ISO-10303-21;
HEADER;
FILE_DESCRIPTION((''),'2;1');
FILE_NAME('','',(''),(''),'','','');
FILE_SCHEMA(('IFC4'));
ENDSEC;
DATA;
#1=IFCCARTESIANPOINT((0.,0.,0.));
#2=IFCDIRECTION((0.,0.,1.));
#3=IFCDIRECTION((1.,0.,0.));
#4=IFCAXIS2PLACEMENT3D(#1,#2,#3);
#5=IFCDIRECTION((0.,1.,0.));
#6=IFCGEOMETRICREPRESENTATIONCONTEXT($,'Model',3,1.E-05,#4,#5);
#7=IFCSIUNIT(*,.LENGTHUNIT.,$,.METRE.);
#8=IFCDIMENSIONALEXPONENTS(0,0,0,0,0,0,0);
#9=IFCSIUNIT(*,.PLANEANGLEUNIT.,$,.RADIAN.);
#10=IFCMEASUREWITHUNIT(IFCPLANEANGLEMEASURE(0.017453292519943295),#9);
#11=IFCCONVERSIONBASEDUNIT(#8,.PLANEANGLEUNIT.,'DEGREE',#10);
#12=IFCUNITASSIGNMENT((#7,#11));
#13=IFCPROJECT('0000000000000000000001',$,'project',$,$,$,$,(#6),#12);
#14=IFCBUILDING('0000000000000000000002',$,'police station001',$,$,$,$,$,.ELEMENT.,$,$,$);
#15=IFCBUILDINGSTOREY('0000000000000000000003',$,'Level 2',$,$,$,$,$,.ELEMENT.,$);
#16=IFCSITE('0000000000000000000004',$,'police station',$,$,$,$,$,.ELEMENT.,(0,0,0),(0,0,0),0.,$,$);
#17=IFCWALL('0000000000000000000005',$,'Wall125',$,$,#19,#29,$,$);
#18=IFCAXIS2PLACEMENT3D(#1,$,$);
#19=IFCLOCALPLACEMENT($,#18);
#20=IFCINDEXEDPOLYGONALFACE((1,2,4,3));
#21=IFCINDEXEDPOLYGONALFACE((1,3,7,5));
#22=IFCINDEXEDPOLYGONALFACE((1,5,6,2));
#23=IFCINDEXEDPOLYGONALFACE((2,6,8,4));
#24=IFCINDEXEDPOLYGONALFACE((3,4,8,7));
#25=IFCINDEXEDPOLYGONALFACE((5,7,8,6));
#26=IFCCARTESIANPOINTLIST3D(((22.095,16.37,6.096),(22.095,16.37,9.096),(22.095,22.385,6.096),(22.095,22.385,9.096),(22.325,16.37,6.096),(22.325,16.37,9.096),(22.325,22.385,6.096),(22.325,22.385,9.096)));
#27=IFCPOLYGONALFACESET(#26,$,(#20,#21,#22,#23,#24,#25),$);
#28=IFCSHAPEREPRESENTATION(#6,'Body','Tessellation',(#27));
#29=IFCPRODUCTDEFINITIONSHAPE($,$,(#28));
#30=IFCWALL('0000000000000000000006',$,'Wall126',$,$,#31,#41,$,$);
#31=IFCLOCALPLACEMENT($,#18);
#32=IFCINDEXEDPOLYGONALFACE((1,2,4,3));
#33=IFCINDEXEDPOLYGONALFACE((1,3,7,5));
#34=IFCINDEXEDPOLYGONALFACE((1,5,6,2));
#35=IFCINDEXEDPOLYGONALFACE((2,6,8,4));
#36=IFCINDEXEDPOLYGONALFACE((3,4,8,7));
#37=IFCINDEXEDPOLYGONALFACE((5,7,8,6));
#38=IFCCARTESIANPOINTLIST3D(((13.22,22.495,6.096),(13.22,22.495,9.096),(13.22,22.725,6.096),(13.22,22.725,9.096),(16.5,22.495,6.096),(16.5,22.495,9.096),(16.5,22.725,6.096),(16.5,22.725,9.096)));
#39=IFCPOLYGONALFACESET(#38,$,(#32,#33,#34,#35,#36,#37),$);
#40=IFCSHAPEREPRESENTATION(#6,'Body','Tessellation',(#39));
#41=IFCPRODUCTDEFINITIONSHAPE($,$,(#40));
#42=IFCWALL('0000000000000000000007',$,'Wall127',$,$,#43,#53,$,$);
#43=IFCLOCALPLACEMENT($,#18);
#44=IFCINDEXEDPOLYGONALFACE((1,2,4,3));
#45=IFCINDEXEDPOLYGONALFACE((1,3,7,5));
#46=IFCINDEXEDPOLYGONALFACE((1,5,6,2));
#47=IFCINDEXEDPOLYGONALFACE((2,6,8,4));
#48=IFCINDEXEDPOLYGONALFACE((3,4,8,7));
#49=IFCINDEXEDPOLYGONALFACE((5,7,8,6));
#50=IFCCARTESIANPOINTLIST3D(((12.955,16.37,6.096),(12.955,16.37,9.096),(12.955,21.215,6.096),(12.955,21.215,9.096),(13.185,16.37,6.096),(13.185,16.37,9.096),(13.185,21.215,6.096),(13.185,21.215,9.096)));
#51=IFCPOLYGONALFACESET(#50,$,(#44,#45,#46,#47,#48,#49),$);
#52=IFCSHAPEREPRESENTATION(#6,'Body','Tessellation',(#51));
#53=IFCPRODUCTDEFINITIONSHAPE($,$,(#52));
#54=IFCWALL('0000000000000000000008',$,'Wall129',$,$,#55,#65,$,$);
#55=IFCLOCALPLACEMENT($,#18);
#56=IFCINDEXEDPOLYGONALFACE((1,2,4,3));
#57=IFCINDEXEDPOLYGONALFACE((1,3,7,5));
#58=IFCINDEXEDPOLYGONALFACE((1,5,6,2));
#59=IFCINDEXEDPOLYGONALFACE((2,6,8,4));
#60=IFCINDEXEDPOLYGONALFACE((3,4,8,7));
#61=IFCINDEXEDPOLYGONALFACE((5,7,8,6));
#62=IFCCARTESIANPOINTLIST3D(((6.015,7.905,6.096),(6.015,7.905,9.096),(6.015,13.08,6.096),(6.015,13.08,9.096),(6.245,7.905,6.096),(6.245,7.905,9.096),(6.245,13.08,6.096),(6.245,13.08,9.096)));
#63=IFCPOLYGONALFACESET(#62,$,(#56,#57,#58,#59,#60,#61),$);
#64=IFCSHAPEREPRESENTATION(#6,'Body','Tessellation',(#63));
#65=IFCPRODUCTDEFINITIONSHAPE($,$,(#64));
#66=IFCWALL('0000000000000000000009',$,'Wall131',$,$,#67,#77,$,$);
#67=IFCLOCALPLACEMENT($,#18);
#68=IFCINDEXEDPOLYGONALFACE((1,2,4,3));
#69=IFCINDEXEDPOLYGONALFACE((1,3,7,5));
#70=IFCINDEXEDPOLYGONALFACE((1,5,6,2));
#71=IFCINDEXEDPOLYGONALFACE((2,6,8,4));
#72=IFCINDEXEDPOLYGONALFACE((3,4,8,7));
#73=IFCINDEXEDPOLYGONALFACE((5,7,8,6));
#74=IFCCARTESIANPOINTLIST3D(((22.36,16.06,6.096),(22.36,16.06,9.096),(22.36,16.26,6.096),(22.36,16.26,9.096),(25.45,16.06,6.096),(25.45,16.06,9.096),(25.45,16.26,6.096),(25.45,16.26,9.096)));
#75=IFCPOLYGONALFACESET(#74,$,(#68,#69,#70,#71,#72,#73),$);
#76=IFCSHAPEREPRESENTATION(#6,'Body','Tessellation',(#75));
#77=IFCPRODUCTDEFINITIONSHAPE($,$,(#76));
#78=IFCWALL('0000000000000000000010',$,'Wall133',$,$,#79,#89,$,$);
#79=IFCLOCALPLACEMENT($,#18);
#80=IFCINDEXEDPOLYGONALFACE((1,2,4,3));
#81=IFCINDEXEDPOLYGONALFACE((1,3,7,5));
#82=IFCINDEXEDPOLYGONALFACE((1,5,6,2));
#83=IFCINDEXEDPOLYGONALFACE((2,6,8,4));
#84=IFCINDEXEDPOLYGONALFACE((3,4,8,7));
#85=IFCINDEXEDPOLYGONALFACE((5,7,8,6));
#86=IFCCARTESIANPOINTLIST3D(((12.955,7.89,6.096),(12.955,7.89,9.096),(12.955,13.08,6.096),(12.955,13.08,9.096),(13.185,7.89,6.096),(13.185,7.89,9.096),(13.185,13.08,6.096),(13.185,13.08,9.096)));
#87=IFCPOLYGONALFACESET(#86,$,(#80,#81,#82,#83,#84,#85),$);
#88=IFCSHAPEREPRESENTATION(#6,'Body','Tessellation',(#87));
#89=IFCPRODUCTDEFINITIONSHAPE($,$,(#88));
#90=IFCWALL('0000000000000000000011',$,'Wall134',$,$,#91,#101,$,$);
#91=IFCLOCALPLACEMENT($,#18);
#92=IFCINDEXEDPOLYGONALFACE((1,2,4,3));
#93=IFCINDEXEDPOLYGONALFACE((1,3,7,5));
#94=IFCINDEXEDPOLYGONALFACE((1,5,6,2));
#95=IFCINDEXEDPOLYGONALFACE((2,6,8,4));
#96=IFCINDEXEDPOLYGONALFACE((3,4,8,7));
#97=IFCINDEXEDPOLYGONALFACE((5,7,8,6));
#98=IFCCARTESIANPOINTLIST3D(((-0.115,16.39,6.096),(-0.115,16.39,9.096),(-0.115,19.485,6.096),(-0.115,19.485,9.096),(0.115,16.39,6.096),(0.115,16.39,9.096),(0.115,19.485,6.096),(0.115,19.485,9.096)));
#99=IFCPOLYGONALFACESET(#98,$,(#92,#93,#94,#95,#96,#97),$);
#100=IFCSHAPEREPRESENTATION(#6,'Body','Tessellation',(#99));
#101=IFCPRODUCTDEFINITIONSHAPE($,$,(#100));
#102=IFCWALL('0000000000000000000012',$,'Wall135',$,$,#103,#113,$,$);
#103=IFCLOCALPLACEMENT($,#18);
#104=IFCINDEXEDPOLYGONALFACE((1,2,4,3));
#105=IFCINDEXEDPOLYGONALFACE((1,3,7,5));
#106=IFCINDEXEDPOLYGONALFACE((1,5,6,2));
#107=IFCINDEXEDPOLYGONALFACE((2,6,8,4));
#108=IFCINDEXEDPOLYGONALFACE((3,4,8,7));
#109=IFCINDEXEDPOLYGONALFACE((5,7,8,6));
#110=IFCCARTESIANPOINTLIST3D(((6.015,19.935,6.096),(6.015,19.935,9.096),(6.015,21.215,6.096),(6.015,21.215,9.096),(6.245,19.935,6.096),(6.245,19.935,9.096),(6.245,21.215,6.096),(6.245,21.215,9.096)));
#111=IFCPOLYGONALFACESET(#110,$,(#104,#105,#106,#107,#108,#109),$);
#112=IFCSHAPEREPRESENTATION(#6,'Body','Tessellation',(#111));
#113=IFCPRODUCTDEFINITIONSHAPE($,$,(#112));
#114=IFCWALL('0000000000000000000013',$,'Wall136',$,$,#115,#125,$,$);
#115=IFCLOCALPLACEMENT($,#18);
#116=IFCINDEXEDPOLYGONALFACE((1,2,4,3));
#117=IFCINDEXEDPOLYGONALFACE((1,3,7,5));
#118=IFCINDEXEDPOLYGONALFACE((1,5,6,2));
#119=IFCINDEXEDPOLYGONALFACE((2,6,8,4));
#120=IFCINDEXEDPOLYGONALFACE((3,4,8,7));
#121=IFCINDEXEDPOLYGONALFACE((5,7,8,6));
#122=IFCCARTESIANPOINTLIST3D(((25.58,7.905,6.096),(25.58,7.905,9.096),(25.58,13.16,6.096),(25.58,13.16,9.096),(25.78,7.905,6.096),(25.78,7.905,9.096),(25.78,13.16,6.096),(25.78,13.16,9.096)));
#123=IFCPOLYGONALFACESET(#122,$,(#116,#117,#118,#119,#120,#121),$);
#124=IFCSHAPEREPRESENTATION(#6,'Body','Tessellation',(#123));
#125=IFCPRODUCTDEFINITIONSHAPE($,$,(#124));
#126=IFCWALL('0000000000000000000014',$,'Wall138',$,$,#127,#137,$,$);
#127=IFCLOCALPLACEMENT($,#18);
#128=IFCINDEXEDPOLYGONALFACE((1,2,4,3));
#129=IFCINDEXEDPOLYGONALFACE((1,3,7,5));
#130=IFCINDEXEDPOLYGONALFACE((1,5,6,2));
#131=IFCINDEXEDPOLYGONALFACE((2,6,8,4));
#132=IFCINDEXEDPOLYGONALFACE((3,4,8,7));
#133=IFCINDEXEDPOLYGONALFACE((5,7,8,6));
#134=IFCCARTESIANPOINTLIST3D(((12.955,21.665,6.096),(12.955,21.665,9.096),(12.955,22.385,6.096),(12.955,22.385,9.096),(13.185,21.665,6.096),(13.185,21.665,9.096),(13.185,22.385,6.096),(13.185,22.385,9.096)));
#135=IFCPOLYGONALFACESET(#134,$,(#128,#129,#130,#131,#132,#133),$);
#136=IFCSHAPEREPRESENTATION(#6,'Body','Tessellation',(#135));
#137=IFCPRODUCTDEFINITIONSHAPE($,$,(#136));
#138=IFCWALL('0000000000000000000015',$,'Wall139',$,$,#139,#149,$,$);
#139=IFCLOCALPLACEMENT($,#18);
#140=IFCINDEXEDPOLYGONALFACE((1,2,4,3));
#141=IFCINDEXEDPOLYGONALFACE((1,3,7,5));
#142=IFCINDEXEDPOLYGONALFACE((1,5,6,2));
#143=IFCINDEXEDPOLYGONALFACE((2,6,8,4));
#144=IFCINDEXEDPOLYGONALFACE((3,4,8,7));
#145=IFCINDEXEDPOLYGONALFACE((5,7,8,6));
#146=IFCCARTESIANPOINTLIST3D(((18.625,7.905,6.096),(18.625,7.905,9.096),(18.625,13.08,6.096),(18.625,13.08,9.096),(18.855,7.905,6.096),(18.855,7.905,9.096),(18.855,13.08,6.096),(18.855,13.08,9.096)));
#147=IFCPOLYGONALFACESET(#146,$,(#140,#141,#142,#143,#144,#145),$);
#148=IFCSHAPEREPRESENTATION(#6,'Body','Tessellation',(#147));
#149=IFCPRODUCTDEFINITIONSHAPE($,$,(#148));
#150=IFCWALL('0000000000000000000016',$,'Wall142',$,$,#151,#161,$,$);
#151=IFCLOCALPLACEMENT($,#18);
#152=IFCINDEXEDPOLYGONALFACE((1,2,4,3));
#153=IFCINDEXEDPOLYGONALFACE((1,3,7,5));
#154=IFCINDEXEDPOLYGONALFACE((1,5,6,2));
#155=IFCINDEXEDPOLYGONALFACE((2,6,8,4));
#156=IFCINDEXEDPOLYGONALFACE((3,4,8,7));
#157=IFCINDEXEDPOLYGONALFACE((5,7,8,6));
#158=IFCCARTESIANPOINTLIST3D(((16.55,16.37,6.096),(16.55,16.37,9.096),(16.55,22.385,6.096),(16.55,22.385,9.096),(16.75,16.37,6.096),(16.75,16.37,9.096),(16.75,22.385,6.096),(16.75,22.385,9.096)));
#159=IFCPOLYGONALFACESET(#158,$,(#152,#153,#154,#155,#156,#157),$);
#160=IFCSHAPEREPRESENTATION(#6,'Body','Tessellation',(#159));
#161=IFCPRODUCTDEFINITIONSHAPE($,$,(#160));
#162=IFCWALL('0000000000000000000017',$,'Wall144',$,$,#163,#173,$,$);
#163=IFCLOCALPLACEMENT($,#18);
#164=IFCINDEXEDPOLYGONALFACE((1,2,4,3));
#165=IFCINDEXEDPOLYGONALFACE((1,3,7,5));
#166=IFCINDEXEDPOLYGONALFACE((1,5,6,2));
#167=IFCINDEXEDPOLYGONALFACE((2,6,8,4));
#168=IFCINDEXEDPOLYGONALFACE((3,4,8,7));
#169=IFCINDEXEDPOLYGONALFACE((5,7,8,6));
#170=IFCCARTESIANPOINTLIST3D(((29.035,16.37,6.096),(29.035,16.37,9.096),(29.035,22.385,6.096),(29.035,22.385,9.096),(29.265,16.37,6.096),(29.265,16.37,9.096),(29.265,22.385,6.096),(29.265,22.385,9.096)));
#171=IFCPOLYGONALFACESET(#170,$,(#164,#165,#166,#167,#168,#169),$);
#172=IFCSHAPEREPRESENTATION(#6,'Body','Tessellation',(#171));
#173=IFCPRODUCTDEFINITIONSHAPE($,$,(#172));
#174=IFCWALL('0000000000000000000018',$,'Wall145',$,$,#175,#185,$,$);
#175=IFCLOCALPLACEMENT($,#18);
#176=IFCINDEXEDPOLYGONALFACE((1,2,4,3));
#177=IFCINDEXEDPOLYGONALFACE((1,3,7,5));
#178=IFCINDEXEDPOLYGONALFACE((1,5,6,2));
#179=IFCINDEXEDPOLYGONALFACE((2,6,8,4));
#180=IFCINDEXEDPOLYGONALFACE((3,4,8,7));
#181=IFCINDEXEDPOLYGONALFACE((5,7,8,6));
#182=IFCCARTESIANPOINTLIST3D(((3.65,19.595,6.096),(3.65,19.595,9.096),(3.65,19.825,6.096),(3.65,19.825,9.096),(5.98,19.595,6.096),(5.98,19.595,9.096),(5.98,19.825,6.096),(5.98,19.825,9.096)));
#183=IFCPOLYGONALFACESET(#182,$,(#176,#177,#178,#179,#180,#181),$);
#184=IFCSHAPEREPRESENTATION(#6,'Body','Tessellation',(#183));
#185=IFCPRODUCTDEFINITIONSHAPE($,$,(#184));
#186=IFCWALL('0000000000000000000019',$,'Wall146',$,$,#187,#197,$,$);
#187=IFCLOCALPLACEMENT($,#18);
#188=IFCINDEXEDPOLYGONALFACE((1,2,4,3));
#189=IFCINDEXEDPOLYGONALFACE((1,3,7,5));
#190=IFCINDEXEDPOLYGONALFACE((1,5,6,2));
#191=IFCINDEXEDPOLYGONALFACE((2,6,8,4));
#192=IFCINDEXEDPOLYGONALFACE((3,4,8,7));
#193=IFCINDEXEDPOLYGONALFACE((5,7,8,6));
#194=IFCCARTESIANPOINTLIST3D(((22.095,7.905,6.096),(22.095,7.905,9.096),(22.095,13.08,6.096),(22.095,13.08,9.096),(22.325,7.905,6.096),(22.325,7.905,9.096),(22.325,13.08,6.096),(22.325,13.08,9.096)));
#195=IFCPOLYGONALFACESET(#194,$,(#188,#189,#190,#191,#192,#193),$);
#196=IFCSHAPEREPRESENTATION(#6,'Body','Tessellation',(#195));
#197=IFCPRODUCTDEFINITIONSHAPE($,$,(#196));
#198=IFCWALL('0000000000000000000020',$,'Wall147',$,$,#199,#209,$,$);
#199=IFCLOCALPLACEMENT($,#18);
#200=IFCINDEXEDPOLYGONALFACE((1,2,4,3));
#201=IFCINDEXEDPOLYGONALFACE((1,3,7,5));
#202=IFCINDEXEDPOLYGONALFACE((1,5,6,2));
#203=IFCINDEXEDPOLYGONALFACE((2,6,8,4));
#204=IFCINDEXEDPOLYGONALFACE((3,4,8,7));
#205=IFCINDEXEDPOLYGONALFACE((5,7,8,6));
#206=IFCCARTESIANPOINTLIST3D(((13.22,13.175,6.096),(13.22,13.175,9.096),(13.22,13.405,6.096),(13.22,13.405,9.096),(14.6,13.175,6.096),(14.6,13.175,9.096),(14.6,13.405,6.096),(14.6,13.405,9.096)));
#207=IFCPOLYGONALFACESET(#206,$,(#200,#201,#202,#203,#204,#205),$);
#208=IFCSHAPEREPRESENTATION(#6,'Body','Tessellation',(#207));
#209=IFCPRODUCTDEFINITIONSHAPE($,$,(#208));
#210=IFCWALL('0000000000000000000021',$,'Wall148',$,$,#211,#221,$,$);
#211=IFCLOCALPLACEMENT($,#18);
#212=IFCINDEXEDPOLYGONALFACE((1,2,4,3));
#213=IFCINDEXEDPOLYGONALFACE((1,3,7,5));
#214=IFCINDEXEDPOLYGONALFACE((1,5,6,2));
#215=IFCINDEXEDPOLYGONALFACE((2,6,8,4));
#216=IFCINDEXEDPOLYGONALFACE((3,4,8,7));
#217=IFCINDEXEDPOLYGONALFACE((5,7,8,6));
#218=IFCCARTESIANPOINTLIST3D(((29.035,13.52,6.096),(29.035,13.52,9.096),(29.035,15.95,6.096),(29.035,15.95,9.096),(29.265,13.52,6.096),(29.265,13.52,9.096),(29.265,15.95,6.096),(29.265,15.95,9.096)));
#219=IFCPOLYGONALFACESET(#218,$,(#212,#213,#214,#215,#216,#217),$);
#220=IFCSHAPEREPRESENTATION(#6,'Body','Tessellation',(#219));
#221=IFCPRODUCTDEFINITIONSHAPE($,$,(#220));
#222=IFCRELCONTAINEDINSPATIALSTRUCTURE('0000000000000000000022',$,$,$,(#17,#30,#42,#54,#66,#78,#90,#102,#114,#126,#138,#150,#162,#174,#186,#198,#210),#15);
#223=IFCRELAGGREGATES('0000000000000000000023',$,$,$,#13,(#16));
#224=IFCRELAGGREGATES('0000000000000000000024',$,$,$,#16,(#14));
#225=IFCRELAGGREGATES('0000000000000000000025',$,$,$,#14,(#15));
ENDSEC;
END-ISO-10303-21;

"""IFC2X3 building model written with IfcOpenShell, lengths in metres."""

from ifc_helpers import new_model, entity, si_unit, converted_unit, direction, frame, frame_2d, origin_with_axes, place, context, project, spatial, rectangle, extrude, element, save


model = new_model("IFC2X3")

# Units and contexts
model_context = context("Model", 3, precision=1e-05, world=origin_with_axes(), true_north=direction((0.0, 1.0, 0.0)))
ifc_project = project(units=[si_unit("LENGTHUNIT", "METRE"), converted_unit("PLANEANGLEUNIT", "DEGREE", entity("IfcPlaneAngleMeasure", 0.017453292519943295), si_unit("PLANEANGLEUNIT", "RADIAN"), dimensions=[0, 0, 0, 0, 0, 0, 0])], contexts=[model_context])

# Site, building, storey
site = spatial("IfcSite", under=ifc_project, Name="police station", CompositionType="ELEMENT", RefLatitude=(0, 0, 0), RefLongitude=(0, 0, 0), RefElevation=0.0)
building = spatial("IfcBuilding", under=site, Name="police station001", CompositionType="ELEMENT")
storey = spatial("IfcBuildingStorey", under=building, Name="Level 2", CompositionType="ELEMENT")

# Shared definitions
placement = place(None, origin_with_axes())

# Walls
element("IfcWall", 1, at=placement, inside=storey, Name="Wall125", context=model_context, shape_type="SweptSolid", body=[
    extrude(rectangle(XDim=6.015, YDim=0.23, at=frame_2d((0.0, 0.0), x_axis=(0.0, -1.0, 0.0))), frame((22.21, 19.3775, 6.096), z_axis=(0.0, 0.0, 1.0), x_axis=(1.0, 0.0, 0.0)), (0.0, 0.0, 1.0), 3.0),
])
element("IfcWall", 2, at=placement, inside=storey, Name="Wall126", context=model_context, shape_type="SweptSolid", body=[
    extrude(rectangle(XDim=3.28, YDim=0.23, at=frame_2d((0.0, 0.0), x_axis=(-1.0, 0.0, 0.0))), frame((14.86, 22.61, 6.096), z_axis=(0.0, 0.0, 1.0), x_axis=(1.0, 0.0, 0.0)), (0.0, 0.0, 1.0), 3.0),
])
element("IfcWall", 3, at=placement, inside=storey, Name="Wall127", context=model_context, shape_type="SweptSolid", body=[
    extrude(rectangle(XDim=4.845, YDim=0.23, at=frame_2d((0.0, 0.0), x_axis=(0.0, -1.0, 0.0))), frame((13.07, 18.7925, 6.096), z_axis=(0.0, 0.0, 1.0), x_axis=(1.0, 0.0, 0.0)), (0.0, 0.0, 1.0), 3.0),
])
element("IfcWall", 4, at=placement, inside=storey, Name="Wall129", context=model_context, shape_type="SweptSolid", body=[
    extrude(rectangle(XDim=5.175, YDim=0.23, at=frame_2d((0.0, 0.0), x_axis=(0.0, -1.0, 0.0))), frame((6.13, 10.4925, 6.096), z_axis=(0.0, 0.0, 1.0), x_axis=(1.0, 0.0, 0.0)), (0.0, 0.0, 1.0), 3.0),
])
element("IfcWall", 5, at=placement, inside=storey, Name="Wall131", context=model_context, shape_type="SweptSolid", body=[
    extrude(rectangle(XDim=3.09, YDim=0.2, at=frame_2d((0.0, 0.0), x_axis=(1.0, 0.0, 0.0))), frame((23.905, 16.16, 6.096), z_axis=(0.0, 0.0, 1.0), x_axis=(1.0, 0.0, 0.0)), (0.0, 0.0, 1.0), 3.0),
])
element("IfcWall", 6, at=placement, inside=storey, Name="Wall133", context=model_context, shape_type="SweptSolid", body=[
    extrude(rectangle(XDim=5.19, YDim=0.23, at=frame_2d((0.0, 0.0), x_axis=(0.0, 1.0, 0.0))), frame((13.07, 10.485, 6.096), z_axis=(0.0, 0.0, 1.0), x_axis=(1.0, 0.0, 0.0)), (0.0, 0.0, 1.0), 3.0),
])
element("IfcWall", 7, at=placement, inside=storey, Name="Wall134", context=model_context, shape_type="SweptSolid", body=[
    extrude(rectangle(XDim=3.095, YDim=0.23, at=frame_2d((0.0, 0.0), x_axis=(0.0, -1.0, 0.0))), frame((0.0, 17.9375, 6.096), z_axis=(0.0, 0.0, 1.0), x_axis=(1.0, 0.0, 0.0)), (0.0, 0.0, 1.0), 3.0),
])
element("IfcWall", 8, at=placement, inside=storey, Name="Wall135", context=model_context, shape_type="SweptSolid", body=[
    extrude(rectangle(XDim=1.28, YDim=0.23, at=frame_2d((0.0, 0.0), x_axis=(0.0, -1.0, 0.0))), frame((6.13, 20.575, 6.096), z_axis=(0.0, 0.0, 1.0), x_axis=(1.0, 0.0, 0.0)), (0.0, 0.0, 1.0), 3.0),
])
element("IfcWall", 9, at=placement, inside=storey, Name="Wall136", context=model_context, shape_type="SweptSolid", body=[
    extrude(rectangle(XDim=5.255, YDim=0.2, at=frame_2d((0.0, 0.0), x_axis=(0.0, -1.0, 0.0))), frame((25.68, 10.5325, 6.096), z_axis=(0.0, 0.0, 1.0), x_axis=(1.0, 0.0, 0.0)), (0.0, 0.0, 1.0), 3.0),
])
element("IfcWall", 10, at=placement, inside=storey, Name="Wall138", context=model_context, shape_type="SweptSolid", body=[
    extrude(rectangle(XDim=0.72, YDim=0.23, at=frame_2d((0.0, 0.0), x_axis=(0.0, 1.0, 0.0))), frame((13.07, 22.025, 6.096), z_axis=(0.0, 0.0, 1.0), x_axis=(1.0, 0.0, 0.0)), (0.0, 0.0, 1.0), 3.0),
])
element("IfcWall", 11, at=placement, inside=storey, Name="Wall139", context=model_context, shape_type="SweptSolid", body=[
    extrude(rectangle(XDim=5.175, YDim=0.23, at=frame_2d((0.0, 0.0), x_axis=(0.0, 1.0, 0.0))), frame((18.74, 10.4925, 6.096), z_axis=(0.0, 0.0, 1.0), x_axis=(1.0, 0.0, 0.0)), (0.0, 0.0, 1.0), 3.0),
])
element("IfcWall", 12, at=placement, inside=storey, Name="Wall142", context=model_context, shape_type="SweptSolid", body=[
    extrude(rectangle(XDim=6.015, YDim=0.2, at=frame_2d((0.0, 0.0), x_axis=(0.0, -1.0, 0.0))), frame((16.65, 19.3775, 6.096), z_axis=(0.0, 0.0, 1.0), x_axis=(1.0, 0.0, 0.0)), (0.0, 0.0, 1.0), 3.0),
])
element("IfcWall", 13, at=placement, inside=storey, Name="Wall144", context=model_context, shape_type="SweptSolid", body=[
    extrude(rectangle(XDim=6.015, YDim=0.23, at=frame_2d((0.0, 0.0), x_axis=(0.0, 1.0, 0.0))), frame((29.15, 19.3775, 6.096), z_axis=(0.0, 0.0, 1.0), x_axis=(1.0, 0.0, 0.0)), (0.0, 0.0, 1.0), 3.0),
])
element("IfcWall", 14, at=placement, inside=storey, Name="Wall145", context=model_context, shape_type="SweptSolid", body=[
    extrude(rectangle(XDim=2.33, YDim=0.23, at=frame_2d((0.0, 0.0), x_axis=(1.0, 0.0, 0.0))), frame((4.815, 19.71, 6.096), z_axis=(0.0, 0.0, 1.0), x_axis=(1.0, 0.0, 0.0)), (0.0, 0.0, 1.0), 3.0),
])
element("IfcWall", 15, at=placement, inside=storey, Name="Wall146", context=model_context, shape_type="SweptSolid", body=[
    extrude(rectangle(XDim=5.175, YDim=0.23, at=frame_2d((0.0, 0.0), x_axis=(0.0, -1.0, 0.0))), frame((22.21, 10.4925, 6.096), z_axis=(0.0, 0.0, 1.0), x_axis=(1.0, 0.0, 0.0)), (0.0, 0.0, 1.0), 3.0),
])
element("IfcWall", 16, at=placement, inside=storey, Name="Wall147", context=model_context, shape_type="SweptSolid", body=[
    extrude(rectangle(XDim=1.38, YDim=0.23, at=frame_2d((0.0, 0.0), x_axis=(1.0, 0.0, 0.0))), frame((13.91, 13.29, 6.096), z_axis=(0.0, 0.0, 1.0), x_axis=(1.0, 0.0, 0.0)), (0.0, 0.0, 1.0), 3.0),
])
element("IfcWall", 17, at=placement, inside=storey, Name="Wall148", context=model_context, shape_type="SweptSolid", body=[
    extrude(rectangle(XDim=2.43, YDim=0.23, at=frame_2d((0.0, 0.0), x_axis=(0.0, -1.0, 0.0))), frame((29.15, 14.735, 6.096), z_axis=(0.0, 0.0, 1.0), x_axis=(1.0, 0.0, 0.0)), (0.0, 0.0, 1.0), 3.0),
])

save(model, "model.ifc")
